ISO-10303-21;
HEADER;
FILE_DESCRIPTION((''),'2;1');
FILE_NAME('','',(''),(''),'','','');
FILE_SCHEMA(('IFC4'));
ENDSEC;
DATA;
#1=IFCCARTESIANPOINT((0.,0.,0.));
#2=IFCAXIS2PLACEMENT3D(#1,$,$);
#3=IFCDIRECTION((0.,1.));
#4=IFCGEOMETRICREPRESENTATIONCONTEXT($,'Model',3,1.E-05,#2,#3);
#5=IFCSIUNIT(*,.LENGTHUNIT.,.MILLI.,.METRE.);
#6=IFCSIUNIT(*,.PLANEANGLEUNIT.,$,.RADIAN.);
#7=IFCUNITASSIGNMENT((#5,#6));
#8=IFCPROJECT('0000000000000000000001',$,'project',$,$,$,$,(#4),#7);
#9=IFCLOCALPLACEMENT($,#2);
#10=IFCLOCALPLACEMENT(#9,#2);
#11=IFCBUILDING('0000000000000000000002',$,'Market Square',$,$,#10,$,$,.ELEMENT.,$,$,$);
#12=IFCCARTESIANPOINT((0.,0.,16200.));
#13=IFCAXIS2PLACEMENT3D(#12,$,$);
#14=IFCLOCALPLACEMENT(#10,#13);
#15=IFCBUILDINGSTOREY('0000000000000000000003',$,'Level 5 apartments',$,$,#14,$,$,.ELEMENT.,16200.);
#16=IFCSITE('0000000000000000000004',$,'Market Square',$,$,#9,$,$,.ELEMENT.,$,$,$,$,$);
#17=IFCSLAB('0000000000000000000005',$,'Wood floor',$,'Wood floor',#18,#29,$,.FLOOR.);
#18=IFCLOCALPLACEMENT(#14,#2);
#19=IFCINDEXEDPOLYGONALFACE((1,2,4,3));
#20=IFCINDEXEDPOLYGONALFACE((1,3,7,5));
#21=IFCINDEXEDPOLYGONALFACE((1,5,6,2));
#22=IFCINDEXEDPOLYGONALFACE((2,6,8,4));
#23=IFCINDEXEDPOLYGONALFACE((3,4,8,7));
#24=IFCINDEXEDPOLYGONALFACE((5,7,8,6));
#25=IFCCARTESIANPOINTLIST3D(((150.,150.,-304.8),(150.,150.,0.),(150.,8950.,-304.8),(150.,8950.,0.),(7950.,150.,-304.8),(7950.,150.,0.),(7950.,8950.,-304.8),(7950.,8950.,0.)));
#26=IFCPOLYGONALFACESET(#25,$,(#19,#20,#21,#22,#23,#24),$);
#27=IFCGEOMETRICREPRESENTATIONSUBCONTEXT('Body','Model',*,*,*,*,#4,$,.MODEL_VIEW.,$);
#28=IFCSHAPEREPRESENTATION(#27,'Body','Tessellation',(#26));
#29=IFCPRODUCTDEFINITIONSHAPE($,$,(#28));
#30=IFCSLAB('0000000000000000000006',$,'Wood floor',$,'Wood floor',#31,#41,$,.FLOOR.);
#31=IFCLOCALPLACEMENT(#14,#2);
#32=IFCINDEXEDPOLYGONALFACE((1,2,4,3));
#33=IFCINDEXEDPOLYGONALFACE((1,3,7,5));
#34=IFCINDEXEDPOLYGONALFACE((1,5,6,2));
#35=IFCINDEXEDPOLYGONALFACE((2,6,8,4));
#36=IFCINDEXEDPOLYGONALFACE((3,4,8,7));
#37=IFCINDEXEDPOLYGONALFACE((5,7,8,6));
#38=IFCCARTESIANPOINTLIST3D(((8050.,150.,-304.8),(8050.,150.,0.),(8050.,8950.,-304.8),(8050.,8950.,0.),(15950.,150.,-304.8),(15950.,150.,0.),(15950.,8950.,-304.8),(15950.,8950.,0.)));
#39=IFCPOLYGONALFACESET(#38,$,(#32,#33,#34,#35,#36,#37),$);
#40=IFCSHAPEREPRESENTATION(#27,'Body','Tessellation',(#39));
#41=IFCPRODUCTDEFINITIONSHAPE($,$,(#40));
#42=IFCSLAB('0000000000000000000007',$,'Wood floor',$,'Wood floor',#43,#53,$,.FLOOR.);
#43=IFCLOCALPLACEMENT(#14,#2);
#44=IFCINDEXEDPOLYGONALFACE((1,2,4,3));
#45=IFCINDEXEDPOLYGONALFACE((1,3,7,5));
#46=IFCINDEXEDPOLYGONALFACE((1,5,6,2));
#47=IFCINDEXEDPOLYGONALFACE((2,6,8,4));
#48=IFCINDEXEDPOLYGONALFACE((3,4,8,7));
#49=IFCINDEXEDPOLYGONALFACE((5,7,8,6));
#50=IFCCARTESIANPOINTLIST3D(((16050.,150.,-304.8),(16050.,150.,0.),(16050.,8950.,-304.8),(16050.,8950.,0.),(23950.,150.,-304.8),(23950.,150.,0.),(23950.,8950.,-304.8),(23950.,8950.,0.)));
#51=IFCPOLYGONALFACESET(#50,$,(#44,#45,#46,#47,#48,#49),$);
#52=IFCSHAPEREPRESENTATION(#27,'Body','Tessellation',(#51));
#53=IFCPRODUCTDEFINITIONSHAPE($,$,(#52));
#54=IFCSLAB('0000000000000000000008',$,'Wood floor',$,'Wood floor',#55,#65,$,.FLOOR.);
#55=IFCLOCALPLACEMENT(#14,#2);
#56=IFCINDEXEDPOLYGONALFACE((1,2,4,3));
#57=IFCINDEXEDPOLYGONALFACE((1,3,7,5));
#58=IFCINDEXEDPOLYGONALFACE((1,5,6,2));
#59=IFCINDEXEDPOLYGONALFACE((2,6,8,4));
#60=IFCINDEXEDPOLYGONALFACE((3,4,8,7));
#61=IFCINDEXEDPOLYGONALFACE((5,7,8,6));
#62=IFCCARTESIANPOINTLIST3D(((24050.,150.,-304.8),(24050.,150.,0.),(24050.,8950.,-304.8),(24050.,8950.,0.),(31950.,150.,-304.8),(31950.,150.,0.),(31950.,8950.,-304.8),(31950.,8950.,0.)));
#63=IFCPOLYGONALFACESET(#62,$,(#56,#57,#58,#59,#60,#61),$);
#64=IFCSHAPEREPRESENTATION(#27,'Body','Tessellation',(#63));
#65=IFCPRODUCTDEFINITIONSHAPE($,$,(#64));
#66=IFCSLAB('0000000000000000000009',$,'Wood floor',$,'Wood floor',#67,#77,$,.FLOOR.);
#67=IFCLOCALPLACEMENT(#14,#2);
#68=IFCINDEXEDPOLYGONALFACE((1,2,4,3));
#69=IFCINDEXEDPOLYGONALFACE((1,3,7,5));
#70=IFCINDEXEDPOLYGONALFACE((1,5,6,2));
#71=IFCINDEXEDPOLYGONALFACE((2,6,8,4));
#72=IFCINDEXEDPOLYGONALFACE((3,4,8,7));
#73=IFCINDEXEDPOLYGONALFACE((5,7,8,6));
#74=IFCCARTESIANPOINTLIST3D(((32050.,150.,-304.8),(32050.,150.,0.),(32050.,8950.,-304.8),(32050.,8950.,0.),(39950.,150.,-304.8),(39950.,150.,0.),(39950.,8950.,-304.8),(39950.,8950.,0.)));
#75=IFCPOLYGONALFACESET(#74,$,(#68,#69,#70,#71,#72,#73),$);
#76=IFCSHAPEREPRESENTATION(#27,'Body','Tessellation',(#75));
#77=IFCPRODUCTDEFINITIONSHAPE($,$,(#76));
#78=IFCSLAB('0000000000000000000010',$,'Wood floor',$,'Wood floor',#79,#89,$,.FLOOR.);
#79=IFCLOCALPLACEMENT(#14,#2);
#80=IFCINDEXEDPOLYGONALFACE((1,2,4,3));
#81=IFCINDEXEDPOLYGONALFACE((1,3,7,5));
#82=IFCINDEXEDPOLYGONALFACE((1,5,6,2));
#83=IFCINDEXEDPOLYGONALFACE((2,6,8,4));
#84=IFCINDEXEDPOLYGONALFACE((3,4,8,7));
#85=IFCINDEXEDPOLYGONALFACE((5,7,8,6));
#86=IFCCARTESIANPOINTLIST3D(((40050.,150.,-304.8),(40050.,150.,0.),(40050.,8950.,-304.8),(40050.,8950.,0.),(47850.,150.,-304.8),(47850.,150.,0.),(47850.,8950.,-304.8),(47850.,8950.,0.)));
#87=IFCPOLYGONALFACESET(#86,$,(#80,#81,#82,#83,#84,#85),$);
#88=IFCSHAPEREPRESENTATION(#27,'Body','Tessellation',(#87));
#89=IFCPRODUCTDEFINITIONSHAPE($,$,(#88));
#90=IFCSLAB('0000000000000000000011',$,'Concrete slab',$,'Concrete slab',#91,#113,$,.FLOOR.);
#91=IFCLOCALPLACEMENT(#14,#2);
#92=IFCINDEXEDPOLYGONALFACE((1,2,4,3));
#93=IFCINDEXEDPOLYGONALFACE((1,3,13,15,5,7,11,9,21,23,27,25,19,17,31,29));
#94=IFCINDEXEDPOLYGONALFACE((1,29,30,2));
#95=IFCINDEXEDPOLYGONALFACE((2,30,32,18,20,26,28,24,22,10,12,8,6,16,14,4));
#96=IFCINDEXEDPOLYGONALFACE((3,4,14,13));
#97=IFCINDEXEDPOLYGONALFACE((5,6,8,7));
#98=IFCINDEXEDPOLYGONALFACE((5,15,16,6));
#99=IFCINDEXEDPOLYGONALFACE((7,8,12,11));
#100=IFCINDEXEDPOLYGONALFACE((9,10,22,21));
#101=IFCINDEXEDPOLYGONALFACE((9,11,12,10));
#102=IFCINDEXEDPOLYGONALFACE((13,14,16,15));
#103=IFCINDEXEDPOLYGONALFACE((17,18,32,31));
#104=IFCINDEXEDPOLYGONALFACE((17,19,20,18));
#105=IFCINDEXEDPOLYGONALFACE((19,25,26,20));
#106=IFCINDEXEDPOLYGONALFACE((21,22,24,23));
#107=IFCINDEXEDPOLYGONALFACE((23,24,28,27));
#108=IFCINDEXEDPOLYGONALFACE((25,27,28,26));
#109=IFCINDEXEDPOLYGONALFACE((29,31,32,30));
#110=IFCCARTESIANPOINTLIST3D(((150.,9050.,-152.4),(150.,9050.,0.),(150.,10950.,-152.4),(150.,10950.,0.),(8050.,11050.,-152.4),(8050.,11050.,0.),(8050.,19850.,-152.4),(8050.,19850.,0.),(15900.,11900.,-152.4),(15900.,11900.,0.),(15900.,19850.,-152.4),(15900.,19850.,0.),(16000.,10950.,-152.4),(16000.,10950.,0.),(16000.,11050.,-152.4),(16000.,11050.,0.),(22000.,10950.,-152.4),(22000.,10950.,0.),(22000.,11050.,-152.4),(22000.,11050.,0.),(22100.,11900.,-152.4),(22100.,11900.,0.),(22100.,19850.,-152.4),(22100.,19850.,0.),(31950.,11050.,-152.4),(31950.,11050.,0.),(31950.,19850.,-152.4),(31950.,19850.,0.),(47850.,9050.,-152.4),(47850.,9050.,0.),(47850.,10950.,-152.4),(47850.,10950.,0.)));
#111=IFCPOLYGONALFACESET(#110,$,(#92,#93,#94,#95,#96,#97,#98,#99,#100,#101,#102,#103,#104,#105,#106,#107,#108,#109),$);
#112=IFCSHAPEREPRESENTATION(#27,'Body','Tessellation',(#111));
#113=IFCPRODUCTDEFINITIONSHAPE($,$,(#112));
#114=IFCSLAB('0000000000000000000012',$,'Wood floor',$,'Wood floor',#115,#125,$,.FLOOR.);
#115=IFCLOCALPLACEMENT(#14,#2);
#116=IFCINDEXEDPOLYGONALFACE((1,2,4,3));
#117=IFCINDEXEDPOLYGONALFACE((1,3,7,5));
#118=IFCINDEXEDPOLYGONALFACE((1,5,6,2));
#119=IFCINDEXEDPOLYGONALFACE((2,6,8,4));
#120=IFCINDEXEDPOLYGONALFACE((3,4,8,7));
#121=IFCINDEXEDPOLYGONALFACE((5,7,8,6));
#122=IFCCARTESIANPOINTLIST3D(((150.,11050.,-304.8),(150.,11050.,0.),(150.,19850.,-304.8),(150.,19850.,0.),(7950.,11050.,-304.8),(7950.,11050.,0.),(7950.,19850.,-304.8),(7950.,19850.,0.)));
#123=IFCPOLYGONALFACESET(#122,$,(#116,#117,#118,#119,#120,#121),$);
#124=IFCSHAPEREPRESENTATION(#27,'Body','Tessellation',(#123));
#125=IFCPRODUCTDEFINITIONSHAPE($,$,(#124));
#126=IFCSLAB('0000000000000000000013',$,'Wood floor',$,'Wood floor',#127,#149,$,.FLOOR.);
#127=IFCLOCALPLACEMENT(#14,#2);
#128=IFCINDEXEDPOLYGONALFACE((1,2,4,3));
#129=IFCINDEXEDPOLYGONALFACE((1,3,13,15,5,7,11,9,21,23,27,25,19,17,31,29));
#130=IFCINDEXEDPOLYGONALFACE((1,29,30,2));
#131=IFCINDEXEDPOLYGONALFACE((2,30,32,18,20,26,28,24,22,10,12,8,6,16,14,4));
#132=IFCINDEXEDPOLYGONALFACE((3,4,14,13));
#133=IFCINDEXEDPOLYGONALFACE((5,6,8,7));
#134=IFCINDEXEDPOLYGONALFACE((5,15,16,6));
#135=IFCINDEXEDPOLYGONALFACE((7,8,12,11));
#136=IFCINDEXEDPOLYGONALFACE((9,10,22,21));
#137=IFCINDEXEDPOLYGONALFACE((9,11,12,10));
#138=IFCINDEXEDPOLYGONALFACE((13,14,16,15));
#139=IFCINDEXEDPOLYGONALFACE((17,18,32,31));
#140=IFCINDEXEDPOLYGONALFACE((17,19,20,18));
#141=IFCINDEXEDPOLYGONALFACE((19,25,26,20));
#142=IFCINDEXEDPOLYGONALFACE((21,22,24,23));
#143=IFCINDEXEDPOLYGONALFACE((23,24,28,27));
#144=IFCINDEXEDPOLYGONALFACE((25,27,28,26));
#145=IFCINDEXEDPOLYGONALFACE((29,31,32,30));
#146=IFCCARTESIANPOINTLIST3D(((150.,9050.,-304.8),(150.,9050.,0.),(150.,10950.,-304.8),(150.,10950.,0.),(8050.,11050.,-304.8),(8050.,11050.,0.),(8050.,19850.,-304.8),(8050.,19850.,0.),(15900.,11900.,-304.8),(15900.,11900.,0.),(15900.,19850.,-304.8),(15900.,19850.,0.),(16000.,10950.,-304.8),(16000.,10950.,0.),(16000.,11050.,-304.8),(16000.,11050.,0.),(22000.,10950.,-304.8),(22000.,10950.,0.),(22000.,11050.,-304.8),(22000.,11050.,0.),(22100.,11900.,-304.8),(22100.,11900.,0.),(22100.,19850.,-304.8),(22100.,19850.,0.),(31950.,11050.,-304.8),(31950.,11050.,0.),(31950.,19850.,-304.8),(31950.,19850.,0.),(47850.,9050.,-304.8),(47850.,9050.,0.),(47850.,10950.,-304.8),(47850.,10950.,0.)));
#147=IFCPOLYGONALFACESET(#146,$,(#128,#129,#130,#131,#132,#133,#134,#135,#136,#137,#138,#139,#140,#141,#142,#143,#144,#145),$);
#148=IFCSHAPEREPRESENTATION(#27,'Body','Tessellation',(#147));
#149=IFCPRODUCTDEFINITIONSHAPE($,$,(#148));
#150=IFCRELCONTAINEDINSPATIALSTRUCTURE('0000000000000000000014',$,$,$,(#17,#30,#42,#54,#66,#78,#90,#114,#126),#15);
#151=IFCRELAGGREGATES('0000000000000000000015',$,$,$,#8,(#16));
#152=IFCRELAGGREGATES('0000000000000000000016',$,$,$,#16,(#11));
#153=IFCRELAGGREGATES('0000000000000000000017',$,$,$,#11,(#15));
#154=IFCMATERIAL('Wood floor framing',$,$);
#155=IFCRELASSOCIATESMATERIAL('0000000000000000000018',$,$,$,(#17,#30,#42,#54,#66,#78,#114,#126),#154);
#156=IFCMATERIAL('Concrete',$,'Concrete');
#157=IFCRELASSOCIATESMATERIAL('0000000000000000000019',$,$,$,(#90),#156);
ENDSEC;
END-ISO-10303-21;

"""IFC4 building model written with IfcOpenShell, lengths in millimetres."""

from ifc_helpers import new_model, si_unit, direction, frame, origin, origin_with_axes, place, context, subcontext, project, spatial, polyline, outline, extrude, material, element, save


model = new_model("IFC4")

# Units and contexts
model_context = context("Model", 3, precision=1e-05, world=origin(), true_north=direction((0.0, 1.0)))
body_context = subcontext(model_context, "Body", "Model", "MODEL_VIEW")
ifc_project = project(units=[si_unit("LENGTHUNIT", "METRE", prefix="MILLI"), si_unit("PLANEANGLEUNIT", "RADIAN")], contexts=[model_context])

# Site, building, storey
site_placement = place(None, origin())
site = spatial("IfcSite", under=ifc_project, at=site_placement, Name="Market Square", CompositionType="ELEMENT")
building_placement = place(site_placement, origin())
building = spatial("IfcBuilding", under=site, at=building_placement, Name="Market Square", CompositionType="ELEMENT")
storey_placement = place(building_placement, frame((0.0, 0.0, 16200.0)))
storey = spatial("IfcBuildingStorey", under=building, at=storey_placement, Name="Level 5 apartments", CompositionType="ELEMENT", Elevation=16200.0)

# Slabs
ifc_material_1 = material(Name="Wood floor framing")
slab_1_placement = place(storey_placement, origin_with_axes())
element("IfcSlab", 1, at=slab_1_placement, inside=storey, material=ifc_material_1, Name="Wood floor", ObjectType="Wood floor", PredefinedType="FLOOR", context=body_context, shape_type="SweptSolid", body=[
    extrude(outline(polyline([(150.0, 150.0), (7950.0, 150.0), (7950.0, 8950.0), (150.0, 8950.0), (150.0, 150.0)])), frame((0.0, 0.0, -304.8)), (0.0, 0.0, 1.0), 304.8),
])
slab_2_placement = place(storey_placement, origin_with_axes())
element("IfcSlab", 2, at=slab_2_placement, inside=storey, material=ifc_material_1, Name="Wood floor", ObjectType="Wood floor", PredefinedType="FLOOR", context=body_context, shape_type="SweptSolid", body=[
    extrude(outline(polyline([(8050.0, 150.0), (15950.0, 150.0), (15950.0, 8950.0), (8050.0, 8950.0), (8050.0, 150.0)])), frame((0.0, 0.0, -304.8)), (0.0, 0.0, 1.0), 304.8),
])
slab_3_placement = place(storey_placement, origin_with_axes())
element("IfcSlab", 3, at=slab_3_placement, inside=storey, material=ifc_material_1, Name="Wood floor", ObjectType="Wood floor", PredefinedType="FLOOR", context=body_context, shape_type="SweptSolid", body=[
    extrude(outline(polyline([(16050.0, 150.0), (23950.0, 150.0), (23950.0, 8950.0), (16050.0, 8950.0), (16050.0, 150.0)])), frame((0.0, 0.0, -304.8)), (0.0, 0.0, 1.0), 304.8),
])
slab_4_placement = place(storey_placement, origin_with_axes())
element("IfcSlab", 4, at=slab_4_placement, inside=storey, material=ifc_material_1, Name="Wood floor", ObjectType="Wood floor", PredefinedType="FLOOR", context=body_context, shape_type="SweptSolid", body=[
    extrude(outline(polyline([(24050.0, 150.0), (31950.0, 150.0), (31950.0, 8950.0), (24050.0, 8950.0), (24050.0, 150.0)])), frame((0.0, 0.0, -304.8)), (0.0, 0.0, 1.0), 304.8),
])
slab_5_placement = place(storey_placement, origin_with_axes())
element("IfcSlab", 5, at=slab_5_placement, inside=storey, material=ifc_material_1, Name="Wood floor", ObjectType="Wood floor", PredefinedType="FLOOR", context=body_context, shape_type="SweptSolid", body=[
    extrude(outline(polyline([(32050.0, 150.0), (39950.0, 150.0), (39950.0, 8950.0), (32050.0, 8950.0), (32050.0, 150.0)])), frame((0.0, 0.0, -304.8)), (0.0, 0.0, 1.0), 304.8),
])
slab_6_placement = place(storey_placement, origin_with_axes())
element("IfcSlab", 6, at=slab_6_placement, inside=storey, material=ifc_material_1, Name="Wood floor", ObjectType="Wood floor", PredefinedType="FLOOR", context=body_context, shape_type="SweptSolid", body=[
    extrude(outline(polyline([(40050.0, 150.0), (47850.0, 150.0), (47850.0, 8950.0), (40050.0, 8950.0), (40050.0, 150.0)])), frame((0.0, 0.0, -304.8)), (0.0, 0.0, 1.0), 304.8),
])
ifc_material_2 = material(Name="Concrete", Category="Concrete")
slab_7_placement = place(storey_placement, origin_with_axes())
element("IfcSlab", 7, at=slab_7_placement, inside=storey, material=ifc_material_2, Name="Concrete slab", ObjectType="Concrete slab", PredefinedType="FLOOR", context=body_context, shape_type="SweptSolid", body=[
    extrude(outline(polyline([(47850.0, 9050.0), (47850.0, 10950.0), (22000.0, 10950.0), (22000.0, 11050.0), (31950.0, 11050.0), (31950.0, 19850.0), (22100.0, 19850.0), (22100.0, 11900.0), (15900.0, 11900.0), (15900.0, 19850.0), (8050.0, 19850.0), (8050.0, 11050.0), (16000.0, 11050.0), (16000.0, 10950.0), (150.0, 10950.0), (150.0, 9050.0), (47850.0, 9050.0)])), frame((0.0, 0.0, -152.4)), (0.0, 0.0, 1.0), 152.4),
])
slab_8_placement = place(storey_placement, origin_with_axes())
element("IfcSlab", 8, at=slab_8_placement, inside=storey, material=ifc_material_1, Name="Wood floor", ObjectType="Wood floor", PredefinedType="FLOOR", context=body_context, shape_type="SweptSolid", body=[
    extrude(outline(polyline([(7950.0, 19850.0), (150.0, 19850.0), (150.0, 11050.0), (7950.0, 11050.0), (7950.0, 19850.0)])), frame((0.0, 0.0, -304.8)), (0.0, 0.0, 1.0), 304.8),
])
for number, where, z_axis, x_axis, name in (
    (9, (0.0, 0.0, 0.0), (0.0, 0.0, 1.0), (1.0, 0.0, 0.0), "Wood floor"),
):
    element("IfcSlab", number, at=place(storey_placement, frame(where, z_axis=z_axis, x_axis=x_axis)), inside=storey, material=ifc_material_1, Name=name, ObjectType="Wood floor", PredefinedType="FLOOR", context=body_context, shape_type="SweptSolid", body=[
        extrude(outline(polyline([(47850.0, 9050.0), (47850.0, 10950.0), (22000.0, 10950.0), (22000.0, 11050.0), (31950.0, 11050.0), (31950.0, 19850.0), (22100.0, 19850.0), (22100.0, 11900.0), (15900.0, 11900.0), (15900.0, 19850.0), (8050.0, 19850.0), (8050.0, 11050.0), (16000.0, 11050.0), (16000.0, 10950.0), (150.0, 10950.0), (150.0, 9050.0), (47850.0, 9050.0)])), frame((0.0, 0.0, -304.8)), (0.0, 0.0, 1.0), 304.8),
    ])

save(model, "model.ifc")
